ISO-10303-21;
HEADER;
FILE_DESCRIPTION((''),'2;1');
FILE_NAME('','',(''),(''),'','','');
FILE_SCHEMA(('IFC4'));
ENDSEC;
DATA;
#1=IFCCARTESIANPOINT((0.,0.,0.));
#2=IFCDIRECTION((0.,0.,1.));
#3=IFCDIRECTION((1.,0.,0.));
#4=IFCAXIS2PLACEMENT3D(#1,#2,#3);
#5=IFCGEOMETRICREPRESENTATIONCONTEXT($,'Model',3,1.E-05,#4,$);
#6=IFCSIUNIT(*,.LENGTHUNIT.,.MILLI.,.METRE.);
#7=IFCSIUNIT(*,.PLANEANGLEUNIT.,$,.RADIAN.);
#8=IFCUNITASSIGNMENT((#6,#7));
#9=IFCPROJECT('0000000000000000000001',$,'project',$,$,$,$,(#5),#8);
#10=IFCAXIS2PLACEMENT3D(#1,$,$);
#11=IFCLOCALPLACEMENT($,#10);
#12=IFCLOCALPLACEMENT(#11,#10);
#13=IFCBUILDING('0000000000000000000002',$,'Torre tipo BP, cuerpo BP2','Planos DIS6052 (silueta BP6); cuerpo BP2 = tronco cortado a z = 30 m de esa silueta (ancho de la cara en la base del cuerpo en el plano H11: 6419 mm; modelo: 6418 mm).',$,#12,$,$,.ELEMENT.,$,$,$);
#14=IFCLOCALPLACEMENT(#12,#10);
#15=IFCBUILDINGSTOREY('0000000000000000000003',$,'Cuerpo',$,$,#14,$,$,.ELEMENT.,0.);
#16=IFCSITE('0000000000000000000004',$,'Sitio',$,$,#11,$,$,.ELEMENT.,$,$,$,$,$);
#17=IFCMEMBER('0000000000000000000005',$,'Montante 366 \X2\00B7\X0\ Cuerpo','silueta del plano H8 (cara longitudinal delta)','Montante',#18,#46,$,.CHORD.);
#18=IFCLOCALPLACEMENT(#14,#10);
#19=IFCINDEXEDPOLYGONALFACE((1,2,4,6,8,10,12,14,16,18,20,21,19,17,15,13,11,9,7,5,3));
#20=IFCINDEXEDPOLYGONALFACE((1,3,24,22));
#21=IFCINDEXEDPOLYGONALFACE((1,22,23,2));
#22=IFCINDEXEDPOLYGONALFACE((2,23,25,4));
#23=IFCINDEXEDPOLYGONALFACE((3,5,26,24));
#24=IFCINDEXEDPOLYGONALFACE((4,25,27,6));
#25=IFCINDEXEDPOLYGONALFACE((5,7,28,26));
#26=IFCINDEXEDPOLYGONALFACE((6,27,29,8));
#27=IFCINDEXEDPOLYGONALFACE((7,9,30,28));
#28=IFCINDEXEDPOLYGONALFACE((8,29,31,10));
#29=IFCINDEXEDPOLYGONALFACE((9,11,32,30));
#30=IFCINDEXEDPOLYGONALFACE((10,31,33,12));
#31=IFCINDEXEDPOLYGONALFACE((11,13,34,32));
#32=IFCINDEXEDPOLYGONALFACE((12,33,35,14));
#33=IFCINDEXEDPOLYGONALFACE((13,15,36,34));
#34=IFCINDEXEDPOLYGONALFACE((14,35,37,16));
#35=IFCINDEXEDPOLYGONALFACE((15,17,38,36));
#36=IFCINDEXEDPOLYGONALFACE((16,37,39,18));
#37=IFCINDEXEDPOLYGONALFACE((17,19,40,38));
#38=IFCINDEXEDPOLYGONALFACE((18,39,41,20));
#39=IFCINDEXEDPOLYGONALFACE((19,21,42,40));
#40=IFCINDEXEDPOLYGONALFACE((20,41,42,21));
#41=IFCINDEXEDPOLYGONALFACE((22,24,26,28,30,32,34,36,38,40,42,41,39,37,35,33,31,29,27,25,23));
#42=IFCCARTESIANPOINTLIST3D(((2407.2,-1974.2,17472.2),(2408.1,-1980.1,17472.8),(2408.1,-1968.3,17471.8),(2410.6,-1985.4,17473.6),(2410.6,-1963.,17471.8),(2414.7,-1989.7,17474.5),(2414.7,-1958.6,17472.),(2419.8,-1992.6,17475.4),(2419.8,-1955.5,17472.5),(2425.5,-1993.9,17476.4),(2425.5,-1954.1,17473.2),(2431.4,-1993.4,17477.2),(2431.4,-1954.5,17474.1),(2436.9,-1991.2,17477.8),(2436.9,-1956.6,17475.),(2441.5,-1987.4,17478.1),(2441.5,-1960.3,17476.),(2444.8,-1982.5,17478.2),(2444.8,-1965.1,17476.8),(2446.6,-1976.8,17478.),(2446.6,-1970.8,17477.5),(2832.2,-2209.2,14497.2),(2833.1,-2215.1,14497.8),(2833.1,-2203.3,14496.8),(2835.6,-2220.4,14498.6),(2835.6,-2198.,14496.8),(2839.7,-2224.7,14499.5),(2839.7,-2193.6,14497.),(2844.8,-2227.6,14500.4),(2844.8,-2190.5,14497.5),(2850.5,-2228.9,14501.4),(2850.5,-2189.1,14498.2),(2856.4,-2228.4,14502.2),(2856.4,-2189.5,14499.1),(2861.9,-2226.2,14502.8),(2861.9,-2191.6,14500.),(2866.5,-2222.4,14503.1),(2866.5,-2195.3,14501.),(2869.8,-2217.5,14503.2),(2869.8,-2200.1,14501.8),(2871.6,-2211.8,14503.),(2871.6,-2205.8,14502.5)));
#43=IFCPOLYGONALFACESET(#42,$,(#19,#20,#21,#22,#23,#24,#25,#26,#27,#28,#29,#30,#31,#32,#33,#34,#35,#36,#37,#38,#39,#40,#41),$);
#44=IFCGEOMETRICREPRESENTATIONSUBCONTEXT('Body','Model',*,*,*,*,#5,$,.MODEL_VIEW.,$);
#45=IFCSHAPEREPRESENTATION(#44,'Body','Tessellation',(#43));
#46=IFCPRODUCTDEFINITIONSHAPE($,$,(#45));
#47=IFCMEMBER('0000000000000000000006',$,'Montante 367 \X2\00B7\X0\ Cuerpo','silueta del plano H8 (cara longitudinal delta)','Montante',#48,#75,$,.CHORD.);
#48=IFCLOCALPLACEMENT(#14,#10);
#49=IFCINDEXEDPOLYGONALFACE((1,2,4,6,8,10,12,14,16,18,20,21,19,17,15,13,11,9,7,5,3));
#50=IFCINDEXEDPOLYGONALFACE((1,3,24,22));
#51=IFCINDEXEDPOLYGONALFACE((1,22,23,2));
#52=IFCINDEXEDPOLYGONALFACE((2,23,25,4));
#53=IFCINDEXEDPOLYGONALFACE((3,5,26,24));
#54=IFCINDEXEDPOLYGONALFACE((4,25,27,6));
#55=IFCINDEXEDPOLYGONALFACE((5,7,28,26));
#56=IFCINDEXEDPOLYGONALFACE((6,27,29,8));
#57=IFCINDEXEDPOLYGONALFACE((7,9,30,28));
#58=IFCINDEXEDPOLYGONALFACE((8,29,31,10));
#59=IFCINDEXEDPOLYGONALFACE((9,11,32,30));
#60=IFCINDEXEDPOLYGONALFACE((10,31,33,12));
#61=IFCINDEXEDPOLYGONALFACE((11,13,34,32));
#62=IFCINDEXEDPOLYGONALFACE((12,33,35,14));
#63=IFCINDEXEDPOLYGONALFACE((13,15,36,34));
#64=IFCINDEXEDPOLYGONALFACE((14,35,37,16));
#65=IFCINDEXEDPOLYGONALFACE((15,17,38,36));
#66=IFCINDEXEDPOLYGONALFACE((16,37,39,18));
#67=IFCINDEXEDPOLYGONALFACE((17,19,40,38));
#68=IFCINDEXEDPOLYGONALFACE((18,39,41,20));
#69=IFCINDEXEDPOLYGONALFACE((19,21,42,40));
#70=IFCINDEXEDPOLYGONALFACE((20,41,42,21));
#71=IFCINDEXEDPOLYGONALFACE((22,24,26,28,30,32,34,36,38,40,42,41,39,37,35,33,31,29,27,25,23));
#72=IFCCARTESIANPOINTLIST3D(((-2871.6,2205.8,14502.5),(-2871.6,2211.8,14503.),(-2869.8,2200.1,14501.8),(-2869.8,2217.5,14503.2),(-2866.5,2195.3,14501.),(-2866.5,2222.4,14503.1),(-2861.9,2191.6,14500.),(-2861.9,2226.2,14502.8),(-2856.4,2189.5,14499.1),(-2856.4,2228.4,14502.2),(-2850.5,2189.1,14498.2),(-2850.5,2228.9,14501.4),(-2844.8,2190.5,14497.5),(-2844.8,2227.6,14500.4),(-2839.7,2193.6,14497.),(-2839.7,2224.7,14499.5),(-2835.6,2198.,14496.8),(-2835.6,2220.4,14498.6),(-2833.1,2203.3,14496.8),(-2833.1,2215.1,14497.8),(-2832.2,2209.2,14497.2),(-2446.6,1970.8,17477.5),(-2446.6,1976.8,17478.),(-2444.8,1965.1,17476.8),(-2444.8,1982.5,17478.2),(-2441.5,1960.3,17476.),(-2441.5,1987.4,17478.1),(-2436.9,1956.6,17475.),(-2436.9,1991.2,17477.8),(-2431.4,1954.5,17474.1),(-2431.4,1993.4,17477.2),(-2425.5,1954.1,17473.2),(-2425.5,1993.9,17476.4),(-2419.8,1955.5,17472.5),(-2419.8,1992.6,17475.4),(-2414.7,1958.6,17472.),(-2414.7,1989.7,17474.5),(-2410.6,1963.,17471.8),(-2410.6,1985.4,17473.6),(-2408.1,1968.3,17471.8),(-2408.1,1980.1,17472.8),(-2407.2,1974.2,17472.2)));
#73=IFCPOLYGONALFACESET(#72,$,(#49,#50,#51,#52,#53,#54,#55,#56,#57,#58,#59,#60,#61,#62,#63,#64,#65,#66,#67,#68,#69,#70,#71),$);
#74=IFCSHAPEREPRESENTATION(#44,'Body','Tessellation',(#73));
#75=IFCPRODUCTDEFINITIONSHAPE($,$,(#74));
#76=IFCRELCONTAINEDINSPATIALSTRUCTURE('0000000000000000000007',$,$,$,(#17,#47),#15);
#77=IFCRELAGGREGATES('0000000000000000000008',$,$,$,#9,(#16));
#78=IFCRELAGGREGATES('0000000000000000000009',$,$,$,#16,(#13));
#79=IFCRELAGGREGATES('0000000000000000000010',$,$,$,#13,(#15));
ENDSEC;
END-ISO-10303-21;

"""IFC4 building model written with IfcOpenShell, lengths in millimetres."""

from ifc_helpers import new_model, si_unit, frame, origin, origin_with_axes, place, context, subcontext, project, spatial, circle, extrude, element, save


model = new_model("IFC4")

# Units and contexts
model_context = context("Model", 3, precision=1e-05, world=origin_with_axes())
body_context = subcontext(model_context, "Body", "Model", "MODEL_VIEW")
ifc_project = project(units=[si_unit("LENGTHUNIT", "METRE", prefix="MILLI"), si_unit("PLANEANGLEUNIT", "RADIAN")], contexts=[model_context])

# Site, building, storey
site_placement = place(None, origin())
site = spatial("IfcSite", under=ifc_project, at=site_placement, Name="Sitio", CompositionType="ELEMENT")
building_placement = place(site_placement, origin())
building = spatial("IfcBuilding", under=site, at=building_placement, Name="Torre tipo BP, cuerpo BP2", Description="Planos DIS6052 (silueta BP6); cuerpo BP2 = tronco cortado a z = 30 m de esa silueta (ancho de la cara en la base del cuerpo en el plano H11: 6419 mm; modelo: 6418 mm).", CompositionType="ELEMENT")
storey_placement = place(building_placement, origin())
storey = spatial("IfcBuildingStorey", under=building, at=storey_placement, Name="Cuerpo", CompositionType="ELEMENT", Elevation=0.0)

# Members
for number, where, z_axis, x_axis, name in (
    (1, (2427.0, -1974.0, 17475.0), (0.140991, -0.07796, -0.986937), (-0.990011, -0.011103, -0.140553), "Montante 366 · Cuerpo"),
    (2, (-2427.0, 1974.0, 17475.0), (-0.140991, 0.07796, -0.986937), (0.990011, 0.011103, -0.140553), "Montante 367 · Cuerpo"),
):
    element("IfcMember", number, at=place(storey_placement, frame(where, z_axis=z_axis, x_axis=x_axis)), inside=storey, Name=name, Description="silueta del plano H8 (cara longitudinal delta)", ObjectType="Montante", PredefinedType="CHORD", context=body_context, shape_type="SweptSolid", body=[
        extrude(circle(Radius=20.0), None, (0.0, 0.0, 1.0), 3014.4),
    ])

save(model, "model.ifc")
